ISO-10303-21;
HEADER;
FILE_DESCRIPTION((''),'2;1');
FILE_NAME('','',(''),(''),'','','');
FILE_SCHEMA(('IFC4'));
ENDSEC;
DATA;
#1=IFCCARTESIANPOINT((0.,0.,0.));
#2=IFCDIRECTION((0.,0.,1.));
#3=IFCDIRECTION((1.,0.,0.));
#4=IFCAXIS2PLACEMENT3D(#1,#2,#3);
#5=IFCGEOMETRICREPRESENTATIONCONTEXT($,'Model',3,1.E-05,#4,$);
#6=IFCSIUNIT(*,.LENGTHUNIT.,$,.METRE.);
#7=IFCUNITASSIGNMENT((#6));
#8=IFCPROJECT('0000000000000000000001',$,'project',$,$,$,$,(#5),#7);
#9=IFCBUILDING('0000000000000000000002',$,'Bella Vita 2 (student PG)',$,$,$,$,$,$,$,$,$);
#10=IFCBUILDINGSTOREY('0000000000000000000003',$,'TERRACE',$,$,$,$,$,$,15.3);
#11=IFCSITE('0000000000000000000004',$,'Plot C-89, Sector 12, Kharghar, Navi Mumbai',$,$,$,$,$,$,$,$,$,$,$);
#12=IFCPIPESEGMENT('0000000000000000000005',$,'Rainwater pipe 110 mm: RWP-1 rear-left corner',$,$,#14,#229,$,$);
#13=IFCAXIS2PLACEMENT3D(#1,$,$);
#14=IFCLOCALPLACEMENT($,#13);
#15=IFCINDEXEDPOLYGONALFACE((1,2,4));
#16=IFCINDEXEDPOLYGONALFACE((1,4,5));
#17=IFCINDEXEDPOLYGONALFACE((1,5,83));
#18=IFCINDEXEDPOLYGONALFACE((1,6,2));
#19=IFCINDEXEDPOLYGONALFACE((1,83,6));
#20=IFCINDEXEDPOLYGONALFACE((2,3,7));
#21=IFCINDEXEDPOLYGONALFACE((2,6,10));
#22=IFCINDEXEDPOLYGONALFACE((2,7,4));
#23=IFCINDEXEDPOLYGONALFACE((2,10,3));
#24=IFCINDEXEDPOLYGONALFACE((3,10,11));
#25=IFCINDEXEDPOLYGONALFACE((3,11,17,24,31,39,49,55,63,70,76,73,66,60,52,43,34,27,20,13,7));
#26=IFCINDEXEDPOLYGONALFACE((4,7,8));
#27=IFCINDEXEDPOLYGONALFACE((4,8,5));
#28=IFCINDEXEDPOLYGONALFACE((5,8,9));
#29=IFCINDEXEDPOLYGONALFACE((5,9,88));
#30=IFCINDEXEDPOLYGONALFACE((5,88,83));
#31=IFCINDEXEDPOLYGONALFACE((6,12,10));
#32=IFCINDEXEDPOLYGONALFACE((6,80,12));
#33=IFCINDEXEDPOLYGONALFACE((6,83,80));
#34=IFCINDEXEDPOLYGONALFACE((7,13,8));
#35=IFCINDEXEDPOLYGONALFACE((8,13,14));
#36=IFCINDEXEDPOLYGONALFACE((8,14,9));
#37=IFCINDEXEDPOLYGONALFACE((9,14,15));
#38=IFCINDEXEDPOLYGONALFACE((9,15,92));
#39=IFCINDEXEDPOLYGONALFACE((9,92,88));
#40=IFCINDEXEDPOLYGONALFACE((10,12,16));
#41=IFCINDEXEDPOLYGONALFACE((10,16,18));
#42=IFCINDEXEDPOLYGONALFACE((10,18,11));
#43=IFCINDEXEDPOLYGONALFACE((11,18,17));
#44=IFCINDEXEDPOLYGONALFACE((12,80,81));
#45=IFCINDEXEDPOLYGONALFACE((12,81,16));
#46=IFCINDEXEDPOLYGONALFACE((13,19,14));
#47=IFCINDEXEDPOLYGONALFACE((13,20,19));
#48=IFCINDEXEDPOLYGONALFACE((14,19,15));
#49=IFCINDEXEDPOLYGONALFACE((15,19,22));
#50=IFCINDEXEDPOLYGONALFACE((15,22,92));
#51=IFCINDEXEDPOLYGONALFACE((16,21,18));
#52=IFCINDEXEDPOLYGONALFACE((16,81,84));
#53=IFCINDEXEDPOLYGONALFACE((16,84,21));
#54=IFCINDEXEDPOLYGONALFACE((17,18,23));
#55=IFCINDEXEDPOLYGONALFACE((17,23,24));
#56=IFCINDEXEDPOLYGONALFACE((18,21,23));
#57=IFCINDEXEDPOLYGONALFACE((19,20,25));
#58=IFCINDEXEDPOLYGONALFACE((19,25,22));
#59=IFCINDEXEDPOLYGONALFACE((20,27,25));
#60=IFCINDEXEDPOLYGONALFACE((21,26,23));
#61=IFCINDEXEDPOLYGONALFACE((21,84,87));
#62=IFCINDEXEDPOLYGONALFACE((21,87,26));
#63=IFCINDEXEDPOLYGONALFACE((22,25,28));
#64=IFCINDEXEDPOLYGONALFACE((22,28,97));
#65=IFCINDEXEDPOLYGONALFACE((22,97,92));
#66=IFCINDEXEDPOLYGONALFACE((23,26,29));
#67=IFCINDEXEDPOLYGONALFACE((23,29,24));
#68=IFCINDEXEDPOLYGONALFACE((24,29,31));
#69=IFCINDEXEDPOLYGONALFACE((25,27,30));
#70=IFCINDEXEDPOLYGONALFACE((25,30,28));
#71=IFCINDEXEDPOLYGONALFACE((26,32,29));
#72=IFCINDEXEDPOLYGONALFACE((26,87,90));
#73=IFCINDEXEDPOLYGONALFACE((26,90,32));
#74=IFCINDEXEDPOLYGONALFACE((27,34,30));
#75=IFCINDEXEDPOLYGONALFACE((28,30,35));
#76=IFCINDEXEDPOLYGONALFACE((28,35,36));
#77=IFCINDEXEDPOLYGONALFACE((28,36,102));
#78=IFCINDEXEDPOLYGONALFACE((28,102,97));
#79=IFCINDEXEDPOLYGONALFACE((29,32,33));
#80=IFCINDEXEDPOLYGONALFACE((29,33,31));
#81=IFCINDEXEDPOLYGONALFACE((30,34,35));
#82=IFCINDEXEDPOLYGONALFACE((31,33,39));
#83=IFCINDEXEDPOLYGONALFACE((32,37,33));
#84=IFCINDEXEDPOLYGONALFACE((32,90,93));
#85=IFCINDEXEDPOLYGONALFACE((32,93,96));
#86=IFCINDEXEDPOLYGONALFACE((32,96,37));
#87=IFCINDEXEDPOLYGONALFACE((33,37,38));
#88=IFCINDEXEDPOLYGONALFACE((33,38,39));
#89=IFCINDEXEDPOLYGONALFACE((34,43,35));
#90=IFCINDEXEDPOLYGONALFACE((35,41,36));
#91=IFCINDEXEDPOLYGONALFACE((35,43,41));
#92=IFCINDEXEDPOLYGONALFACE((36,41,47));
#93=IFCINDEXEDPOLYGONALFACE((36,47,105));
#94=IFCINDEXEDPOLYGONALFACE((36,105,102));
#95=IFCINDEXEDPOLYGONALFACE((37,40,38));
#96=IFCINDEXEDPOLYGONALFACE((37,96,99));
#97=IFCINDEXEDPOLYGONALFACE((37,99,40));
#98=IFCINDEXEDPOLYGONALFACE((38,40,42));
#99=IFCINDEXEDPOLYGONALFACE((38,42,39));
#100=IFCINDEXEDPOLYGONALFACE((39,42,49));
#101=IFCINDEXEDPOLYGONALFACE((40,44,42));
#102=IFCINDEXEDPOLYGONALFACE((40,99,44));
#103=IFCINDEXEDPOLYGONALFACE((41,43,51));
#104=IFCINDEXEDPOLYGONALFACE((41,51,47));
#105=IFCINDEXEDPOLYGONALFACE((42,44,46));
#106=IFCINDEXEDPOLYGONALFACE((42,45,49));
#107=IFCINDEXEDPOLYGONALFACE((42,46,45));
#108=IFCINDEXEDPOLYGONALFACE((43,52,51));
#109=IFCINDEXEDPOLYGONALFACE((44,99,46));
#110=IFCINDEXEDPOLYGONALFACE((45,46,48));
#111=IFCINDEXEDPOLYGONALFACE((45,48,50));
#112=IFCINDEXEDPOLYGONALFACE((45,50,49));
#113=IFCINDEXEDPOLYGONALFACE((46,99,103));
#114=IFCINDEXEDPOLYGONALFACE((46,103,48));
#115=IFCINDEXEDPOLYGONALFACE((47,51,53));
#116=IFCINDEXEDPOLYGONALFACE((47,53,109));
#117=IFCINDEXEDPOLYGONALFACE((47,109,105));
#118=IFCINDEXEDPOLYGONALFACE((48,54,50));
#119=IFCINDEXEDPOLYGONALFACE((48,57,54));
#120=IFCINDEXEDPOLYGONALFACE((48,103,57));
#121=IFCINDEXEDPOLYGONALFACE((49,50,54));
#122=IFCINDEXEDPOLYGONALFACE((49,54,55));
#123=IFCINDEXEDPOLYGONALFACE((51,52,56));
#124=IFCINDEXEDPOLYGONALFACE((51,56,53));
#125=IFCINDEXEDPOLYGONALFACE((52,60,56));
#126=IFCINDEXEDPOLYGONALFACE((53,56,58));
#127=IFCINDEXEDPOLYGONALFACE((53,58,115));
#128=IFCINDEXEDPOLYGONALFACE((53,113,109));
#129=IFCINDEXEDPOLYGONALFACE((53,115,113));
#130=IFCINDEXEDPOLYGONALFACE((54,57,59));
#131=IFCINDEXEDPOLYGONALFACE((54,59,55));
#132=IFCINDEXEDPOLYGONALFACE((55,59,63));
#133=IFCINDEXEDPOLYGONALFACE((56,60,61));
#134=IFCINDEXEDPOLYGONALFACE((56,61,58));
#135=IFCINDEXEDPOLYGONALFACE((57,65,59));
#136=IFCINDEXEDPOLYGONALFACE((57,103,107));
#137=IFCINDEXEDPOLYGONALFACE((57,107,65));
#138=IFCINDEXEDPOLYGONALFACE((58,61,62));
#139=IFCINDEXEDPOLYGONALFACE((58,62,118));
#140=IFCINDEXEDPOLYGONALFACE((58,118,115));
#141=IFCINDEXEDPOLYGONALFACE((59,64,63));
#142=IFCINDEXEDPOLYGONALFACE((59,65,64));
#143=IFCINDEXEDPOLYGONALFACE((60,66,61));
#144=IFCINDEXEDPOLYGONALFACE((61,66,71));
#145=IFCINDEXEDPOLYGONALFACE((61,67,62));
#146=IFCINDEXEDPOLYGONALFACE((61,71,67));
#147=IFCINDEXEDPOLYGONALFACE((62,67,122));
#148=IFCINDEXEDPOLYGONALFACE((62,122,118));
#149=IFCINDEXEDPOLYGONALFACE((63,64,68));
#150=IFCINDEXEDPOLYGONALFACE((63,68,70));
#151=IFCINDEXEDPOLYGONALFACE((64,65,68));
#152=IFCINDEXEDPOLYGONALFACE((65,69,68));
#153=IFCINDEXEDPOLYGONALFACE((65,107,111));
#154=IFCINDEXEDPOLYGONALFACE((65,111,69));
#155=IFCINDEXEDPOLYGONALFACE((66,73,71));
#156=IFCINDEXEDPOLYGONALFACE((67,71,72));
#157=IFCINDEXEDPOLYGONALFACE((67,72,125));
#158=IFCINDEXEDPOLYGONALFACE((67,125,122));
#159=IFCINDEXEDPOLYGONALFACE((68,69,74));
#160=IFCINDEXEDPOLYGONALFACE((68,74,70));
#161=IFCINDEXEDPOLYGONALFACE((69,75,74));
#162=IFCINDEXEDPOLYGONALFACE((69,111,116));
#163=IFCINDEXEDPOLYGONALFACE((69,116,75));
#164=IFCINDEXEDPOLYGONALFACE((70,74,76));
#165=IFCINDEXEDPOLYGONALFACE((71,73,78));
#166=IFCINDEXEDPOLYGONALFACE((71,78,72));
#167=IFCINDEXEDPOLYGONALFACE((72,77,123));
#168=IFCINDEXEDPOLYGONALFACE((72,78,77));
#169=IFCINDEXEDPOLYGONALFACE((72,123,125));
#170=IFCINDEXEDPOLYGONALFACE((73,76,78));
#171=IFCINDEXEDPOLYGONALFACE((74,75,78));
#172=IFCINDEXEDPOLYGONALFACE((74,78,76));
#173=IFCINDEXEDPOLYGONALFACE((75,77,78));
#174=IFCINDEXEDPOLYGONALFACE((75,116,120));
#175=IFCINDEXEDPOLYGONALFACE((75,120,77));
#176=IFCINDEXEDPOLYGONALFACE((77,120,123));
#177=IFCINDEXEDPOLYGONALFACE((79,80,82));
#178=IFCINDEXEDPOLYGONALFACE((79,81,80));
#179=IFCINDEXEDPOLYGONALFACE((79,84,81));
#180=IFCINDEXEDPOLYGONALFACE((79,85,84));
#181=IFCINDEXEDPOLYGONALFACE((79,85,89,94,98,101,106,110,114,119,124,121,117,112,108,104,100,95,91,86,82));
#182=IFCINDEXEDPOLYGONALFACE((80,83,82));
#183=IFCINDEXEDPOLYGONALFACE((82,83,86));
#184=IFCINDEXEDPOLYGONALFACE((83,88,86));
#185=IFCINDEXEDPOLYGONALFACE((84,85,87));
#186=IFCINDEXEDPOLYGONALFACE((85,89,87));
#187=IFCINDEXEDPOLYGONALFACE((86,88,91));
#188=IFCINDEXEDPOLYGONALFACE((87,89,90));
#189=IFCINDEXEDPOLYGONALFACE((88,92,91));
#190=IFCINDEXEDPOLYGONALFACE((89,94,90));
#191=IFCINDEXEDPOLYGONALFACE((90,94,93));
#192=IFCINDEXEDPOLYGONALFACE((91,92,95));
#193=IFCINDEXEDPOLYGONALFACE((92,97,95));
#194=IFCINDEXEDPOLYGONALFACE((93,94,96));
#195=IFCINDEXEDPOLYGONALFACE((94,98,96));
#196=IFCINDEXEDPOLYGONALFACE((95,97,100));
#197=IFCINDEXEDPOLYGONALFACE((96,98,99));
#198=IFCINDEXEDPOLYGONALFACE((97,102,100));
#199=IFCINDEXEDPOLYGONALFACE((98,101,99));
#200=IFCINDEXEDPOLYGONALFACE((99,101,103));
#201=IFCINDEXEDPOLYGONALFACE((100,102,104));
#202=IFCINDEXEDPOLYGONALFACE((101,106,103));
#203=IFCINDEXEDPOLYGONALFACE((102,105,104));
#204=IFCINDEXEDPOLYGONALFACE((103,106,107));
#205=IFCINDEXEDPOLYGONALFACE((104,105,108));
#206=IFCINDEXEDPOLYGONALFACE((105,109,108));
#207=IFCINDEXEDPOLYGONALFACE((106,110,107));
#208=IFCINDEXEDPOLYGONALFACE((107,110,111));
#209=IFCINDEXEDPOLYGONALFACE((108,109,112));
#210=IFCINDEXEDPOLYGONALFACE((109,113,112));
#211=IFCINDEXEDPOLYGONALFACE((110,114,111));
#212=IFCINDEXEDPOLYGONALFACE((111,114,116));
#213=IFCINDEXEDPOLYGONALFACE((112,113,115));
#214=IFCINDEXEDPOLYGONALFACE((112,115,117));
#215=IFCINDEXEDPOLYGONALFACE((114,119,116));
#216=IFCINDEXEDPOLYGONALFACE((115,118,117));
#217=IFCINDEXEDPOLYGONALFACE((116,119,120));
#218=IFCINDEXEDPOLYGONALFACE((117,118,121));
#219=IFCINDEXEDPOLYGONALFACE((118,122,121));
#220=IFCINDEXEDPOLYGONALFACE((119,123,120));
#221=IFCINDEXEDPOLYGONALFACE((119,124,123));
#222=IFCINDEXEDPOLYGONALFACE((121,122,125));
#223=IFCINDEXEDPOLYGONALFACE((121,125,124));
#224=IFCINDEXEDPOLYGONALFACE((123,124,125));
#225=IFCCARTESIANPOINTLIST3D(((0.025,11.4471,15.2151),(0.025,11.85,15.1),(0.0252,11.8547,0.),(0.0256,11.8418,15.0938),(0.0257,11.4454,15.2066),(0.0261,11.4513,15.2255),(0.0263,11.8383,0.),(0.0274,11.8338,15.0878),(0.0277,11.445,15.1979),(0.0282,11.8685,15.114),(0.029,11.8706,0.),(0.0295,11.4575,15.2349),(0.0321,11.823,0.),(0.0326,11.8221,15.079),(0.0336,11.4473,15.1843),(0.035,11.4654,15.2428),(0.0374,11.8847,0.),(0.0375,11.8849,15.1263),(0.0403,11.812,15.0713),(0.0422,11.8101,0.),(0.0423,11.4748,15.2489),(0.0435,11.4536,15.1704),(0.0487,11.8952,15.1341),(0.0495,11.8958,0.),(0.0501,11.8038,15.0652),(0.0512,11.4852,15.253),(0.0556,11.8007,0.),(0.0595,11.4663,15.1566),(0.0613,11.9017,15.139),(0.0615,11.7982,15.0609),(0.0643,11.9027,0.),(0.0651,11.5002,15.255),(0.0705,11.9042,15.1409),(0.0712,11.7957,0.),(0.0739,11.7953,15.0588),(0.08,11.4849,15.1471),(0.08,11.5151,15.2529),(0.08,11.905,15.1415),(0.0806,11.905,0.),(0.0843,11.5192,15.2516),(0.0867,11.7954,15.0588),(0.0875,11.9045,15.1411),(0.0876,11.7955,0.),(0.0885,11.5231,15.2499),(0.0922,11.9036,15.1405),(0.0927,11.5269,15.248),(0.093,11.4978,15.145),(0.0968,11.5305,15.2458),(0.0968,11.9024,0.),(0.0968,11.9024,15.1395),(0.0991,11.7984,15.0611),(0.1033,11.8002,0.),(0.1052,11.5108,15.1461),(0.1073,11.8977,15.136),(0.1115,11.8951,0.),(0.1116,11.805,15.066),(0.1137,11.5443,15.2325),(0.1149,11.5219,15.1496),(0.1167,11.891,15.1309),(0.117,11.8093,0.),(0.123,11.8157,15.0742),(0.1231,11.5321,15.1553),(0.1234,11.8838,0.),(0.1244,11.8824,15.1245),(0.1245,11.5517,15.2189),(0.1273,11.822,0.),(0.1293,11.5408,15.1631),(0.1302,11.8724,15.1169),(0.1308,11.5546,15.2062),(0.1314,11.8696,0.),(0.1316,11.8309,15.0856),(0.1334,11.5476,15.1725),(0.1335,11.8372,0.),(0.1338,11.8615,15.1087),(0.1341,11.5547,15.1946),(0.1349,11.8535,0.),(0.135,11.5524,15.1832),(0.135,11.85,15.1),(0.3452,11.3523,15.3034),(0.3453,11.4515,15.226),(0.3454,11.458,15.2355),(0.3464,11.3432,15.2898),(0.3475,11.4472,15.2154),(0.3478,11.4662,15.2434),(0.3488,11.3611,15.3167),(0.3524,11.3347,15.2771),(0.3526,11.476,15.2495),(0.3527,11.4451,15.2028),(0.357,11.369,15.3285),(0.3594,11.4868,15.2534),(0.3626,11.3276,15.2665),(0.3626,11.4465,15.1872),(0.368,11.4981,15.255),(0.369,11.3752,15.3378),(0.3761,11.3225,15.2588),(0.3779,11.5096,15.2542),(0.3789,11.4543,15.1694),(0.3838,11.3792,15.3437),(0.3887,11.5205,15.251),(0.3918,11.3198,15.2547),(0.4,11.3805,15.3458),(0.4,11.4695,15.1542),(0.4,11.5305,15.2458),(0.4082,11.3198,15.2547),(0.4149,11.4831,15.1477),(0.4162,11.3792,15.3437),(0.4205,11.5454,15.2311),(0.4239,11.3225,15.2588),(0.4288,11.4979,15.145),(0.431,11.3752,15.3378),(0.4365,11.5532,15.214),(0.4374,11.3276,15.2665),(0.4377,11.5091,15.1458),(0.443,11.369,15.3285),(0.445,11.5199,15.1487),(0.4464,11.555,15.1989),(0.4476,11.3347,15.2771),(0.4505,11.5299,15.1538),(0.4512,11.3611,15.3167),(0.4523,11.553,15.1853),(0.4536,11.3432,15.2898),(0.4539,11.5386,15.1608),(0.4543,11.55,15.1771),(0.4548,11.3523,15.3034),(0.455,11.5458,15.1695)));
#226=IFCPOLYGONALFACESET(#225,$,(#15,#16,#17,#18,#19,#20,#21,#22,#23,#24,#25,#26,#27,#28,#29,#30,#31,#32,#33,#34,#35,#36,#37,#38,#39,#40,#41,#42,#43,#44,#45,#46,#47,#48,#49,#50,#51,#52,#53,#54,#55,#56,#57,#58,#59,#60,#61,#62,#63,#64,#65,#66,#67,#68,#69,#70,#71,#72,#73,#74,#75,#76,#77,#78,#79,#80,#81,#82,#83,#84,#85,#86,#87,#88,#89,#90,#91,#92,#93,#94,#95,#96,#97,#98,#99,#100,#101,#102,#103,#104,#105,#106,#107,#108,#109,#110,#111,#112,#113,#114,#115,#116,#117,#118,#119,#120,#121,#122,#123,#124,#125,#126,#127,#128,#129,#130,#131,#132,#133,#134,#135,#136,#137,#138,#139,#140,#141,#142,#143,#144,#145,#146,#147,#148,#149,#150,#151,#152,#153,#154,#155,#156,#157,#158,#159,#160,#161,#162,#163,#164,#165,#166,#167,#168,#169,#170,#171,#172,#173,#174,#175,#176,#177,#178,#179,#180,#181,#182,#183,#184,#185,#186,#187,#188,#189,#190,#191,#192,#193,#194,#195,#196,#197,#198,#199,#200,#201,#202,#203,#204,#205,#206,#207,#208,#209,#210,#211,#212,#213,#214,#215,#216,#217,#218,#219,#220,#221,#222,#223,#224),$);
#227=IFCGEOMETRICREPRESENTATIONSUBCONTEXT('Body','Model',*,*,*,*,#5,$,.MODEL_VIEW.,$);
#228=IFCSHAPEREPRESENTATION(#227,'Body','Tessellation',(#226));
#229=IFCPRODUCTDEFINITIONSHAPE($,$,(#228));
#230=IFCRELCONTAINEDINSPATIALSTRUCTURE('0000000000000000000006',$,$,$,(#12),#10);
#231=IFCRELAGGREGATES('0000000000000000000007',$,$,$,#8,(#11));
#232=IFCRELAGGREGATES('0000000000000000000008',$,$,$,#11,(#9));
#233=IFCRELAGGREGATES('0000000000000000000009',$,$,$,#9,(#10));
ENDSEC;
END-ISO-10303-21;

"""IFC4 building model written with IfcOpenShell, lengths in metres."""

from ifc_helpers import new_model, entity, si_unit, origin, origin_with_axes, place, context, subcontext, project, spatial, element, save


model = new_model("IFC4")

# Units and contexts
model_context = context("Model", 3, precision=1e-05, world=origin_with_axes())
body_context = subcontext(model_context, "Body", "Model", "MODEL_VIEW")
ifc_project = project(units=[si_unit("LENGTHUNIT", "METRE")], contexts=[model_context])

# Site, building, storey
site = spatial("IfcSite", under=ifc_project, Name="Plot C-89, Sector 12, Kharghar, Navi Mumbai")
building = spatial("IfcBuilding", under=site, Name="Bella Vita 2 (student PG)")
storey = spatial("IfcBuildingStorey", under=building, Name="TERRACE", Elevation=15.3)

# Pipe segment
pipe_segment_1_placement = place(None, origin())
element("IfcPipeSegment", 1, at=pipe_segment_1_placement, inside=storey, Name="Rainwater pipe 110 mm: RWP-1 rear-left corner", context=body_context, shape_type="AdvancedSweptSolid", body=[
    entity("IfcSweptDiskSolid", entity("IfcPolyline", [entity("IfcCartesianPoint", [0.4, 11.35, 15.3]), entity("IfcCartesianPoint", [0.4, 11.5, 15.2]), entity("IfcCartesianPoint", [0.08, 11.5, 15.2]), entity("IfcCartesianPoint", [0.08, 11.85, 15.1]), entity("IfcCartesianPoint", [0.08, 11.85, 0.0])]), 0.055),
])

save(model, "model.ifc")
